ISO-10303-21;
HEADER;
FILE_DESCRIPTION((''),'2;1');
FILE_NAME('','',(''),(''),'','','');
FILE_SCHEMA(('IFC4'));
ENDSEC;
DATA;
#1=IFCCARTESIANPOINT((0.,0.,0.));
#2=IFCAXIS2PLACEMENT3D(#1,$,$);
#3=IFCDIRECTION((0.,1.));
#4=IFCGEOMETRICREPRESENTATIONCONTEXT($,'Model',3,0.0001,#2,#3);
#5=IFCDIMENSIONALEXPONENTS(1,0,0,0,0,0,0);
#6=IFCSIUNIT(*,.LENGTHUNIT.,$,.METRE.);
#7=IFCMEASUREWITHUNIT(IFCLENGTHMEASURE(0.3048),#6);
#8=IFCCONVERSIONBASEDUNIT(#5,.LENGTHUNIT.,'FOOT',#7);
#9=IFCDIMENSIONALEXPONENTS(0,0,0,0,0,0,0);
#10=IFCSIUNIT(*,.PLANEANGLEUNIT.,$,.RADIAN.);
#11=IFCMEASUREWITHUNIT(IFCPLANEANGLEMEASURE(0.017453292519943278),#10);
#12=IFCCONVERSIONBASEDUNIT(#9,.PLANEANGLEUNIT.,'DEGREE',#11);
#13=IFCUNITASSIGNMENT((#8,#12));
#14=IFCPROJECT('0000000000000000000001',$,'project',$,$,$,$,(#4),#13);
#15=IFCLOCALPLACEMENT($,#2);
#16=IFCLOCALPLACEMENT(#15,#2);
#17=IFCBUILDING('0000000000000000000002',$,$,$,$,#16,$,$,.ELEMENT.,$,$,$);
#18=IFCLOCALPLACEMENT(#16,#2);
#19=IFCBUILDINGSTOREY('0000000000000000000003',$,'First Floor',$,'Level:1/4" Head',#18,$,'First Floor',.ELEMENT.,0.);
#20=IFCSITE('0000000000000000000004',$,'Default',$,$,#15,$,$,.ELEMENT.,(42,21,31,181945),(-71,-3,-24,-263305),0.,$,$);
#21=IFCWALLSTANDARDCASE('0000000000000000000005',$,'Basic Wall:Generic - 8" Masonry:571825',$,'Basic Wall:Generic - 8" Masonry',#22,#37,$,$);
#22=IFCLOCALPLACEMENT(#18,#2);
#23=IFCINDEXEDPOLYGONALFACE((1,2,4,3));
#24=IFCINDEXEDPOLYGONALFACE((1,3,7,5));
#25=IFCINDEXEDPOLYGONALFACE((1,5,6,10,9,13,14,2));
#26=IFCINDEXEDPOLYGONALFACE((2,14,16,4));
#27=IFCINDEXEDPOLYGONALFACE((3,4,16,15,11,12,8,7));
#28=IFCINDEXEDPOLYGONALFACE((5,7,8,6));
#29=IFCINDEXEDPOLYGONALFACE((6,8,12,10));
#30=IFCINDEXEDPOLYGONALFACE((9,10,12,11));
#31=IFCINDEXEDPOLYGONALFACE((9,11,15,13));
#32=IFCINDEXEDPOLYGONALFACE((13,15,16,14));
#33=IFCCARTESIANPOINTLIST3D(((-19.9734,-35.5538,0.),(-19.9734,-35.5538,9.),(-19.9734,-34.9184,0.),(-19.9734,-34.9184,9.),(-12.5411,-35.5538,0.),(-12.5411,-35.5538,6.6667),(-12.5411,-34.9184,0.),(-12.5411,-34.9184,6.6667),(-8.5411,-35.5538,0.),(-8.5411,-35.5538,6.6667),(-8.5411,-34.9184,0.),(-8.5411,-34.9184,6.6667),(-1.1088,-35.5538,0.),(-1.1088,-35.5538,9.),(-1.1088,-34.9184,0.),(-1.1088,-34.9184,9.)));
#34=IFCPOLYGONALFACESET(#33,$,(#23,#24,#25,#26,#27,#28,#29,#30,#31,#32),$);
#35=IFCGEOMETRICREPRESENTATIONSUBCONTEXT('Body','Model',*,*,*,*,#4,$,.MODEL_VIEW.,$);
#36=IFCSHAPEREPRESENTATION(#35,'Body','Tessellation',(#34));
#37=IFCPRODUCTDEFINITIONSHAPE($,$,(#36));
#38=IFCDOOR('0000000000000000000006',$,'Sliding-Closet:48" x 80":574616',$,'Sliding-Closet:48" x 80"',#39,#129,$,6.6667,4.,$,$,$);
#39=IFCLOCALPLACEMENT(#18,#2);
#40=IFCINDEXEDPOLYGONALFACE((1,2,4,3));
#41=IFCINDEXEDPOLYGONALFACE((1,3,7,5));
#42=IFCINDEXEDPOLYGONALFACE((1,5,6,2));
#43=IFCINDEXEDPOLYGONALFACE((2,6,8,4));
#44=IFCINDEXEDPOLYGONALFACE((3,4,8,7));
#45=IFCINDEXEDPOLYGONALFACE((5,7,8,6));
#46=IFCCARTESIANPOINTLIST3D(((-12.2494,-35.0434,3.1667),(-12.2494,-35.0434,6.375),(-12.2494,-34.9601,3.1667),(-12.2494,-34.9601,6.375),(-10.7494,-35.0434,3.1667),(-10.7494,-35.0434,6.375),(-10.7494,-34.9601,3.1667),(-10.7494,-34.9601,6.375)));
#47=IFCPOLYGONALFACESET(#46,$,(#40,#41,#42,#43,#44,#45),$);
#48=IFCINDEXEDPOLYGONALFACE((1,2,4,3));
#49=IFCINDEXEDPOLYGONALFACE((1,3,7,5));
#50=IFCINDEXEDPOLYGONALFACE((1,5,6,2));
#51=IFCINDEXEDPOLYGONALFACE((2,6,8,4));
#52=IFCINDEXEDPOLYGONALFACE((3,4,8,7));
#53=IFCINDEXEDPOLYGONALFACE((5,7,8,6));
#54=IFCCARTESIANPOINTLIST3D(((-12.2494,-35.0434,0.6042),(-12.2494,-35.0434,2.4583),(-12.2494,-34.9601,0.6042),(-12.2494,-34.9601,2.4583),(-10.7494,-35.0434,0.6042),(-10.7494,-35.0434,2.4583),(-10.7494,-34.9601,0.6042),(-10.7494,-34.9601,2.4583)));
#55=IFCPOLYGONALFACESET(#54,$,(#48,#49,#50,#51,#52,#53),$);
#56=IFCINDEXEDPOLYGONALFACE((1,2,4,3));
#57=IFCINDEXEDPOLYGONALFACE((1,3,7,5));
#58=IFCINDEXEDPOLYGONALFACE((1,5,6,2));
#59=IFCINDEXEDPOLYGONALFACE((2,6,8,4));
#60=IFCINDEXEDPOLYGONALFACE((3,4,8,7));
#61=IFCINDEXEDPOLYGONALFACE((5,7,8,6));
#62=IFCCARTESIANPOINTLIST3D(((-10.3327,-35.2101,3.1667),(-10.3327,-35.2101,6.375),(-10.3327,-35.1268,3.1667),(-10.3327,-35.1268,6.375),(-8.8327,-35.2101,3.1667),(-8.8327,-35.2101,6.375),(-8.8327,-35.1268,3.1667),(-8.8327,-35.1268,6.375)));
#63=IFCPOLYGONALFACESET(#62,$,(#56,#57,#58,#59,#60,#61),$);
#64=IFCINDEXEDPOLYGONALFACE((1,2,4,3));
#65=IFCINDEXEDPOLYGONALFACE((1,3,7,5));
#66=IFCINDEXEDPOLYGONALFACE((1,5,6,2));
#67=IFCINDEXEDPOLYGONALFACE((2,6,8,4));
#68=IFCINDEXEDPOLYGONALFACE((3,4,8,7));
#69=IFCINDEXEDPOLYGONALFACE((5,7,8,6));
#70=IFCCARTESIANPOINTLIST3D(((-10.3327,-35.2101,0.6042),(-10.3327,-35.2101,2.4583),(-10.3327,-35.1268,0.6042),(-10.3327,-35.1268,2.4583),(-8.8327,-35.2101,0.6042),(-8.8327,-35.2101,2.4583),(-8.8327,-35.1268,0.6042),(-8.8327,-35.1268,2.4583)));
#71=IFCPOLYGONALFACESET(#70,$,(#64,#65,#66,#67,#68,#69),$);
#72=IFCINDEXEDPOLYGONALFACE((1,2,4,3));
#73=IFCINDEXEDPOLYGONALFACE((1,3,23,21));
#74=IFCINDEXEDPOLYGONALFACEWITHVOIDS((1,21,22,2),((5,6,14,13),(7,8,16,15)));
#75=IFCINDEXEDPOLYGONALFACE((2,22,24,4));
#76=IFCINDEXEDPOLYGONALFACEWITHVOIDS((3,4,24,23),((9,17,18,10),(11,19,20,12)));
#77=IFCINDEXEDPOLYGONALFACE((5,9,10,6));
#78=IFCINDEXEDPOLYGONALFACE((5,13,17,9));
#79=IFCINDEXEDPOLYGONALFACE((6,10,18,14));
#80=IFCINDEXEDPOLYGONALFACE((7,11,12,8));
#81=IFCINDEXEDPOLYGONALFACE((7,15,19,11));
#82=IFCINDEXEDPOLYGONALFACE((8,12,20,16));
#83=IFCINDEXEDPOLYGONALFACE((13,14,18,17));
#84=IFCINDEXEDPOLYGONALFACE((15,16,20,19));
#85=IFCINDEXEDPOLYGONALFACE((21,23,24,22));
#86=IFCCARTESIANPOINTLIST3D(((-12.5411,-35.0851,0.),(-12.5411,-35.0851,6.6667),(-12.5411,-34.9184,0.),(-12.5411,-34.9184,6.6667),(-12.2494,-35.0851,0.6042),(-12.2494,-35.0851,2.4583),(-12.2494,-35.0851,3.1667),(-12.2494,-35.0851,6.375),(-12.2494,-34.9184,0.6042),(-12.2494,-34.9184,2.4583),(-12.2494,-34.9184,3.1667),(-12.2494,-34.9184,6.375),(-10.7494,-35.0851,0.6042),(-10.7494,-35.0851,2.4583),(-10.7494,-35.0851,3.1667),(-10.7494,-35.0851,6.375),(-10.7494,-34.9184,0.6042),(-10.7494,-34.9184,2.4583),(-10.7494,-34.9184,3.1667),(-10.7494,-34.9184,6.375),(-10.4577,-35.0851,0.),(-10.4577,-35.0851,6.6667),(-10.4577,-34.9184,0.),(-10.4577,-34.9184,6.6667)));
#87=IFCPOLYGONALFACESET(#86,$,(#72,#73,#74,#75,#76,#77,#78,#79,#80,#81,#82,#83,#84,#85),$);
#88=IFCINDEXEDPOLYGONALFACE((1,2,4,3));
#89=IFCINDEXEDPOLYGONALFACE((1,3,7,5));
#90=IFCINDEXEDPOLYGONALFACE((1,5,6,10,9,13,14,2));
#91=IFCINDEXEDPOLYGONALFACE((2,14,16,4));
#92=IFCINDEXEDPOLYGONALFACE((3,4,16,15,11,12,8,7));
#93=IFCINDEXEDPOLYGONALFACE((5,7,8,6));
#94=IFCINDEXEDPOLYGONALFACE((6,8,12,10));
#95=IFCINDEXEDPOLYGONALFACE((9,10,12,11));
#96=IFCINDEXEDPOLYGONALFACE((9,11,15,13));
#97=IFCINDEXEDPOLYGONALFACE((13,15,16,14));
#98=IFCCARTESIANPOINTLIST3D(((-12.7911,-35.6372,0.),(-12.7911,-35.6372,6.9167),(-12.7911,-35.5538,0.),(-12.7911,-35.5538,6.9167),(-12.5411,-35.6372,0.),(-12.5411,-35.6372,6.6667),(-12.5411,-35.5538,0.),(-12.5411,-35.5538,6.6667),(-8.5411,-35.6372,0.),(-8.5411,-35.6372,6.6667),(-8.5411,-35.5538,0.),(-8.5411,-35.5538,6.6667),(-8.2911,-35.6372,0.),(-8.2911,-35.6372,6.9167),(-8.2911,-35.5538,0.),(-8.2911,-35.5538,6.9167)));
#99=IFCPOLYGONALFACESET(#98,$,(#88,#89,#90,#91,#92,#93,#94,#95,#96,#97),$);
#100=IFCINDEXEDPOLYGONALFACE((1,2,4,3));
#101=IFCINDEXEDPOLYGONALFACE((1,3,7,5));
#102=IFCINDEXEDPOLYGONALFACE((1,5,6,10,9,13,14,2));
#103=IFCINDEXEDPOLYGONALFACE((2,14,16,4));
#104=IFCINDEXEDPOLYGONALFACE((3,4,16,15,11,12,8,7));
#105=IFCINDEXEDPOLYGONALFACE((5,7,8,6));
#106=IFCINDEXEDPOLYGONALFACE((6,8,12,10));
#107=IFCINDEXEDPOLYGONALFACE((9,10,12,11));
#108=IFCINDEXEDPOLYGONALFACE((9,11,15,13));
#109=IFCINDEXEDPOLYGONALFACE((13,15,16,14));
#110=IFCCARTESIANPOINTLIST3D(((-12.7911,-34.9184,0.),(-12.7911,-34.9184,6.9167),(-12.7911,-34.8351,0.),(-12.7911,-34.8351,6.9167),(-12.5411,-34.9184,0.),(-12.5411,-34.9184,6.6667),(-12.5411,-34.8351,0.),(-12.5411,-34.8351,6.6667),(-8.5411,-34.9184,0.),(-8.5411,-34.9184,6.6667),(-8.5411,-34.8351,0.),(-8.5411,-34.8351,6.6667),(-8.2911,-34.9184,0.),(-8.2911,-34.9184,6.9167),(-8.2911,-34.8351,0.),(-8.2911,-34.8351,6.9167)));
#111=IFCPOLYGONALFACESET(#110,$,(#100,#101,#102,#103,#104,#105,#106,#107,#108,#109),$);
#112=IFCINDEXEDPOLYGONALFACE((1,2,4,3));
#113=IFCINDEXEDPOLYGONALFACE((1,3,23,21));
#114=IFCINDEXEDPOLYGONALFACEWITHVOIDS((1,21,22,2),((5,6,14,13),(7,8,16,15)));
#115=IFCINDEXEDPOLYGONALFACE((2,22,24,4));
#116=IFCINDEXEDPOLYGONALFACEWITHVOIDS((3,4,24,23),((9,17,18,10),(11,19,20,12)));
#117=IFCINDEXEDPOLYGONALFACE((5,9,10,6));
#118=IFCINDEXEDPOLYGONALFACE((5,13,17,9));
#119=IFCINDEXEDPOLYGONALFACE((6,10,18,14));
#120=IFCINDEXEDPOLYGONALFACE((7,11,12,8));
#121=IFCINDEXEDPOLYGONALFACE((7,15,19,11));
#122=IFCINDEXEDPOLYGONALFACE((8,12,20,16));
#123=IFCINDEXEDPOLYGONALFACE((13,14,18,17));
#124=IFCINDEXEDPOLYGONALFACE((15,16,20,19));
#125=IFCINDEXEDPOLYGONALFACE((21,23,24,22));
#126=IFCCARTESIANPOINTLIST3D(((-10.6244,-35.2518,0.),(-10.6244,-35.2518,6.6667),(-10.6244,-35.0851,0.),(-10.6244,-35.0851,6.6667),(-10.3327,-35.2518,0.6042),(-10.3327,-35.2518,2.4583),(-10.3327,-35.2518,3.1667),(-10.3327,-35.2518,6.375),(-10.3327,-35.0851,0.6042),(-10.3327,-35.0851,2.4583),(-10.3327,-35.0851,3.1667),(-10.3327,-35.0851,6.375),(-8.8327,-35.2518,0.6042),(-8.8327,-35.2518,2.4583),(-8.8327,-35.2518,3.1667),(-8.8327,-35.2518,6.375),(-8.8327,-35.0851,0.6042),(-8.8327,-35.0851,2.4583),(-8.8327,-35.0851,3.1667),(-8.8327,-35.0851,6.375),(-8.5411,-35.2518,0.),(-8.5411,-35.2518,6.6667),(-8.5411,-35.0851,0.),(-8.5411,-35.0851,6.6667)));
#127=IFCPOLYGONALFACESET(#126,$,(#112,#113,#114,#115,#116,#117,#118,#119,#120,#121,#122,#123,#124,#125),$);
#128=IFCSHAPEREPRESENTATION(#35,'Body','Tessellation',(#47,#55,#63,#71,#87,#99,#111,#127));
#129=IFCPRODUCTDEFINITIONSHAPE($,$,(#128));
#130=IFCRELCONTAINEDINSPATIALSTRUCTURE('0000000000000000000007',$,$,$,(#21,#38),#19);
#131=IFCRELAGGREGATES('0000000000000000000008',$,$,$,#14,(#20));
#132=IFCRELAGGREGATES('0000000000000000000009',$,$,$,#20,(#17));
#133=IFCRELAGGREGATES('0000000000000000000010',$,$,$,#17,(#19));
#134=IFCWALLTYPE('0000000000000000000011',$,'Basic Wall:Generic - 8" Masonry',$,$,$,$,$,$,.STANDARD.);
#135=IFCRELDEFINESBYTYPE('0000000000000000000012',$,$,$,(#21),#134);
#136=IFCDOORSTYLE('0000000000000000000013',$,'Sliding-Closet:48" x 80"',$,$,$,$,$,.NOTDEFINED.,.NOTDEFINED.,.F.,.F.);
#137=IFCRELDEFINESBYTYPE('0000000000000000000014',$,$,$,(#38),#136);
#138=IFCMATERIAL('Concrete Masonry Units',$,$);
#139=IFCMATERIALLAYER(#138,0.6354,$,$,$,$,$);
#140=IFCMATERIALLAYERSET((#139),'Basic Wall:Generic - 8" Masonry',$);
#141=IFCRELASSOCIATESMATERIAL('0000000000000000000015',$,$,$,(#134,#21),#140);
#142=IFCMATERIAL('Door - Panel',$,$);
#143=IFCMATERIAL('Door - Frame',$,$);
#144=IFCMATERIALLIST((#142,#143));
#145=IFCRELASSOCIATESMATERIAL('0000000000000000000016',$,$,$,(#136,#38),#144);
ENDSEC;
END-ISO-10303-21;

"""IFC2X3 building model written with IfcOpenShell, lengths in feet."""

from ifc_helpers import new_model, entity, si_unit, converted_unit, direction, frame, frame_2d, origin, origin_2d_with_axis, place, context, subcontext, project, spatial, polyline, rectangle, outline, extrude, source, transform, mapped, material, material_list, layer, layer_set, layer_usage, type_object, type_shapes, element, fill, save


model = new_model("IFC2X3")

# Units and contexts
model_context = context("Model", 3, precision=0.0001, world=origin(), true_north=direction((0.0, 1.0)))
body_context = subcontext(model_context, "Body", "Model", "MODEL_VIEW")
ifc_project = project(units=[converted_unit("LENGTHUNIT", "FOOT", entity("IfcLengthMeasure", 0.3048), si_unit("LENGTHUNIT", "METRE"), dimensions=[1, 0, 0, 0, 0, 0, 0]), converted_unit("PLANEANGLEUNIT", "DEGREE", entity("IfcPlaneAngleMeasure", 0.017453292519943278), si_unit("PLANEANGLEUNIT", "RADIAN"), dimensions=[0, 0, 0, 0, 0, 0, 0])], contexts=[model_context])

# Site, building, storey
site_placement = place(None, origin())
site = spatial("IfcSite", under=ifc_project, at=site_placement, Name="Default", CompositionType="ELEMENT", RefLatitude=(42, 21, 31, 181945), RefLongitude=(-71, -3, -24, -263305), RefElevation=0.0)
building_placement = place(site_placement, origin())
building = spatial("IfcBuilding", under=site, at=building_placement, CompositionType="ELEMENT")
storey_placement = place(building_placement, origin())
storey = spatial("IfcBuildingStorey", under=building, at=storey_placement, Name="First Floor", ObjectType="Level:1/4\" Head", LongName="First Floor", CompositionType="ELEMENT", Elevation=0.0)

# Shared definitions
ifc_material_1 = material(Name="Concrete Masonry Units")
ifc_layer = layer(ifc_material_1, 0.6354)
ifc_layer_set = layer_set([ifc_layer], Name="Basic Wall:Generic - 8\" Masonry")
wall_type = type_object("IfcWallType", Name="Basic Wall:Generic - 8\" Masonry", PredefinedType="STANDARD", material=ifc_layer_set)

# Wall, opening, door
ifc_layer_usage_1 = layer_usage(ifc_layer_set, "AXIS2", "NEGATIVE", 0.3177)
wall_1_placement = place(storey_placement, frame((-1.1088, -35.2361, 0.0), z_axis=(0.0, 0.0, 1.0), x_axis=(-1.0, 0.0, 0.0)))
wall_1 = element("IfcWallStandardCase", 1, at=wall_1_placement, inside=storey, type_object=wall_type, material=ifc_layer_usage_1, Name="Basic Wall:Generic - 8\" Masonry:571825", ObjectType="Basic Wall:Generic - 8\" Masonry", context=body_context, shape_type="SweptSolid", body=[
    extrude(rectangle(XDim=18.8646, YDim=0.6354, at=frame_2d((9.4323, 0.0), x_axis=(-1.0, 0.0))), origin(), (0.0, 0.0, 1.0), 9.0),
])
opening_1_placement = place(wall_1_placement, frame((11.4323, 0.3177, 0.0)))
opening_1 = element("IfcOpeningElement", 2, at=opening_1_placement, cuts=wall_1, ObjectType="Opening", context=body_context, shape_type="SweptSolid", body=[
    extrude(rectangle(XDim=6.6667, YDim=4.0, at=frame_2d((3.3333, 2.0), x_axis=(-1.0, 0.0))), frame((0.0, 0.0, 0.0), z_axis=(0.0, -1.0, 0.0), x_axis=(0.0, 0.0, 1.0)), (0.0, 0.0, 1.0), 0.6354),
])
ifc_material_2 = material(Name="Door - Panel")
ifc_material_3 = material(Name="Door - Frame")
ifc_material_list_1 = material_list([ifc_material_2, ifc_material_3])
door_style = type_object("IfcDoorStyle", Name="Sliding-Closet:48\" x 80\"", ConstructionType="NOTDEFINED", OperationType="NOTDEFINED", ParameterTakesPrecedence=False, Sizeable=False, material=ifc_material_list_1)
shared_shape_1 = source(origin(), body_context, "Body", "SweptSolid", [
    extrude(rectangle(XDim=0.0833, YDim=1.5, at=origin_2d_with_axis()), frame((1.0417, 0.5521, 3.1667), z_axis=(0.0, 0.0, 1.0), x_axis=(0.0, 1.0, 0.0)), (0.0, 0.0, 1.0), 3.2083),
    extrude(rectangle(XDim=0.0833, YDim=1.5, at=origin_2d_with_axis()), frame((1.0417, 0.5521, 0.6042), z_axis=(0.0, 0.0, 1.0), x_axis=(0.0, 1.0, 0.0)), (0.0, 0.0, 1.0), 1.8542),
    extrude(rectangle(XDim=0.0833, YDim=1.5, at=frame_2d((0.0, 0.0), x_axis=(1.0, 0.0))), frame((2.9583, 0.3854, 3.1667), z_axis=(0.0, 0.0, 1.0), x_axis=(0.0, -1.0, 0.0)), (0.0, 0.0, 1.0), 3.2083),
    extrude(rectangle(XDim=0.0833, YDim=1.5, at=frame_2d((0.0, 0.0), x_axis=(1.0, 0.0))), frame((2.9583, 0.3854, 0.6042), z_axis=(0.0, 0.0, 1.0), x_axis=(0.0, -1.0, 0.0)), (0.0, 0.0, 1.0), 1.8542),
    extrude(outline(polyline([(-3.3333, -1.0417), (3.3333, -1.0417), (3.3333, 1.0417), (-3.3333, 1.0417), (-3.3333, -1.0417)]), holes=[polyline([(2.7292, 0.75), (2.7292, -0.75), (0.875, -0.75), (0.875, 0.75), (2.7292, 0.75)]), polyline([(0.1667, 0.75), (0.1667, -0.75), (-3.0417, -0.75), (-3.0417, 0.75), (0.1667, 0.75)])]), frame((1.0417, 0.4688, 3.3333), z_axis=(0.0, 1.0, 0.0), x_axis=(0.0, 0.0, -1.0)), (0.0, 0.0, 1.0), 0.1667),
    extrude(outline(polyline([(-3.3958, -2.25), (3.5208, -2.25), (3.5208, 2.25), (-3.3958, 2.25), (-3.3958, 2.0), (3.2708, 2.0), (3.2708, -2.0), (-3.3958, -2.0), (-3.3958, -2.25)])), frame((2.0, -0.0833, 3.3958), z_axis=(0.0, 1.0, 0.0), x_axis=(0.0, 0.0, 1.0)), (0.0, 0.0, 1.0), 0.0833),
    extrude(outline(polyline([(-2.25, -3.3958), (-2.0, -3.3958), (-2.0, 3.2708), (2.0, 3.2708), (2.0, -3.3958), (2.25, -3.3958), (2.25, 3.5208), (-2.25, 3.5208), (-2.25, -3.3958)])), frame((2.0, 0.6354, 3.3958), z_axis=(0.0, 1.0, 0.0), x_axis=(-1.0, 0.0, 0.0)), (0.0, 0.0, 1.0), 0.0833),
    extrude(outline(polyline([(-1.0417, -3.3333), (1.0417, -3.3333), (1.0417, 3.3333), (-1.0417, 3.3333), (-1.0417, -3.3333)]), holes=[polyline([(0.75, 0.1667), (0.75, -3.0417), (-0.75, -3.0417), (-0.75, 0.1667), (0.75, 0.1667)]), polyline([(0.75, 2.7292), (0.75, 0.875), (-0.75, 0.875), (-0.75, 2.7292), (0.75, 2.7292)])]), frame((2.9583, 0.3021, 3.3333), z_axis=(0.0, 1.0, 0.0), x_axis=(1.0, 0.0, 0.0)), (0.0, 0.0, 1.0), 0.1667),
])
type_shapes(door_style, [shared_shape_1])
door_placement = place(opening_1_placement, frame((0.0, 0.0, 0.0), z_axis=(0.0, 0.0, 1.0), x_axis=(-1.0, 0.0, 0.0)))
door = element("IfcDoor", 3, at=door_placement, inside=storey, type_object=door_style, material=ifc_material_list_1, Name="Sliding-Closet:48\" x 80\":574616", ObjectType="Sliding-Closet:48\" x 80\"", OverallHeight=6.6667, OverallWidth=4.0, context=body_context, shape_type="MappedRepresentation", body=[
    mapped(shared_shape_1, transform((0.0, 0.0, 0.0), scale=1.0)),
])
fill(opening_1, door)

save(model, "model.ifc")
